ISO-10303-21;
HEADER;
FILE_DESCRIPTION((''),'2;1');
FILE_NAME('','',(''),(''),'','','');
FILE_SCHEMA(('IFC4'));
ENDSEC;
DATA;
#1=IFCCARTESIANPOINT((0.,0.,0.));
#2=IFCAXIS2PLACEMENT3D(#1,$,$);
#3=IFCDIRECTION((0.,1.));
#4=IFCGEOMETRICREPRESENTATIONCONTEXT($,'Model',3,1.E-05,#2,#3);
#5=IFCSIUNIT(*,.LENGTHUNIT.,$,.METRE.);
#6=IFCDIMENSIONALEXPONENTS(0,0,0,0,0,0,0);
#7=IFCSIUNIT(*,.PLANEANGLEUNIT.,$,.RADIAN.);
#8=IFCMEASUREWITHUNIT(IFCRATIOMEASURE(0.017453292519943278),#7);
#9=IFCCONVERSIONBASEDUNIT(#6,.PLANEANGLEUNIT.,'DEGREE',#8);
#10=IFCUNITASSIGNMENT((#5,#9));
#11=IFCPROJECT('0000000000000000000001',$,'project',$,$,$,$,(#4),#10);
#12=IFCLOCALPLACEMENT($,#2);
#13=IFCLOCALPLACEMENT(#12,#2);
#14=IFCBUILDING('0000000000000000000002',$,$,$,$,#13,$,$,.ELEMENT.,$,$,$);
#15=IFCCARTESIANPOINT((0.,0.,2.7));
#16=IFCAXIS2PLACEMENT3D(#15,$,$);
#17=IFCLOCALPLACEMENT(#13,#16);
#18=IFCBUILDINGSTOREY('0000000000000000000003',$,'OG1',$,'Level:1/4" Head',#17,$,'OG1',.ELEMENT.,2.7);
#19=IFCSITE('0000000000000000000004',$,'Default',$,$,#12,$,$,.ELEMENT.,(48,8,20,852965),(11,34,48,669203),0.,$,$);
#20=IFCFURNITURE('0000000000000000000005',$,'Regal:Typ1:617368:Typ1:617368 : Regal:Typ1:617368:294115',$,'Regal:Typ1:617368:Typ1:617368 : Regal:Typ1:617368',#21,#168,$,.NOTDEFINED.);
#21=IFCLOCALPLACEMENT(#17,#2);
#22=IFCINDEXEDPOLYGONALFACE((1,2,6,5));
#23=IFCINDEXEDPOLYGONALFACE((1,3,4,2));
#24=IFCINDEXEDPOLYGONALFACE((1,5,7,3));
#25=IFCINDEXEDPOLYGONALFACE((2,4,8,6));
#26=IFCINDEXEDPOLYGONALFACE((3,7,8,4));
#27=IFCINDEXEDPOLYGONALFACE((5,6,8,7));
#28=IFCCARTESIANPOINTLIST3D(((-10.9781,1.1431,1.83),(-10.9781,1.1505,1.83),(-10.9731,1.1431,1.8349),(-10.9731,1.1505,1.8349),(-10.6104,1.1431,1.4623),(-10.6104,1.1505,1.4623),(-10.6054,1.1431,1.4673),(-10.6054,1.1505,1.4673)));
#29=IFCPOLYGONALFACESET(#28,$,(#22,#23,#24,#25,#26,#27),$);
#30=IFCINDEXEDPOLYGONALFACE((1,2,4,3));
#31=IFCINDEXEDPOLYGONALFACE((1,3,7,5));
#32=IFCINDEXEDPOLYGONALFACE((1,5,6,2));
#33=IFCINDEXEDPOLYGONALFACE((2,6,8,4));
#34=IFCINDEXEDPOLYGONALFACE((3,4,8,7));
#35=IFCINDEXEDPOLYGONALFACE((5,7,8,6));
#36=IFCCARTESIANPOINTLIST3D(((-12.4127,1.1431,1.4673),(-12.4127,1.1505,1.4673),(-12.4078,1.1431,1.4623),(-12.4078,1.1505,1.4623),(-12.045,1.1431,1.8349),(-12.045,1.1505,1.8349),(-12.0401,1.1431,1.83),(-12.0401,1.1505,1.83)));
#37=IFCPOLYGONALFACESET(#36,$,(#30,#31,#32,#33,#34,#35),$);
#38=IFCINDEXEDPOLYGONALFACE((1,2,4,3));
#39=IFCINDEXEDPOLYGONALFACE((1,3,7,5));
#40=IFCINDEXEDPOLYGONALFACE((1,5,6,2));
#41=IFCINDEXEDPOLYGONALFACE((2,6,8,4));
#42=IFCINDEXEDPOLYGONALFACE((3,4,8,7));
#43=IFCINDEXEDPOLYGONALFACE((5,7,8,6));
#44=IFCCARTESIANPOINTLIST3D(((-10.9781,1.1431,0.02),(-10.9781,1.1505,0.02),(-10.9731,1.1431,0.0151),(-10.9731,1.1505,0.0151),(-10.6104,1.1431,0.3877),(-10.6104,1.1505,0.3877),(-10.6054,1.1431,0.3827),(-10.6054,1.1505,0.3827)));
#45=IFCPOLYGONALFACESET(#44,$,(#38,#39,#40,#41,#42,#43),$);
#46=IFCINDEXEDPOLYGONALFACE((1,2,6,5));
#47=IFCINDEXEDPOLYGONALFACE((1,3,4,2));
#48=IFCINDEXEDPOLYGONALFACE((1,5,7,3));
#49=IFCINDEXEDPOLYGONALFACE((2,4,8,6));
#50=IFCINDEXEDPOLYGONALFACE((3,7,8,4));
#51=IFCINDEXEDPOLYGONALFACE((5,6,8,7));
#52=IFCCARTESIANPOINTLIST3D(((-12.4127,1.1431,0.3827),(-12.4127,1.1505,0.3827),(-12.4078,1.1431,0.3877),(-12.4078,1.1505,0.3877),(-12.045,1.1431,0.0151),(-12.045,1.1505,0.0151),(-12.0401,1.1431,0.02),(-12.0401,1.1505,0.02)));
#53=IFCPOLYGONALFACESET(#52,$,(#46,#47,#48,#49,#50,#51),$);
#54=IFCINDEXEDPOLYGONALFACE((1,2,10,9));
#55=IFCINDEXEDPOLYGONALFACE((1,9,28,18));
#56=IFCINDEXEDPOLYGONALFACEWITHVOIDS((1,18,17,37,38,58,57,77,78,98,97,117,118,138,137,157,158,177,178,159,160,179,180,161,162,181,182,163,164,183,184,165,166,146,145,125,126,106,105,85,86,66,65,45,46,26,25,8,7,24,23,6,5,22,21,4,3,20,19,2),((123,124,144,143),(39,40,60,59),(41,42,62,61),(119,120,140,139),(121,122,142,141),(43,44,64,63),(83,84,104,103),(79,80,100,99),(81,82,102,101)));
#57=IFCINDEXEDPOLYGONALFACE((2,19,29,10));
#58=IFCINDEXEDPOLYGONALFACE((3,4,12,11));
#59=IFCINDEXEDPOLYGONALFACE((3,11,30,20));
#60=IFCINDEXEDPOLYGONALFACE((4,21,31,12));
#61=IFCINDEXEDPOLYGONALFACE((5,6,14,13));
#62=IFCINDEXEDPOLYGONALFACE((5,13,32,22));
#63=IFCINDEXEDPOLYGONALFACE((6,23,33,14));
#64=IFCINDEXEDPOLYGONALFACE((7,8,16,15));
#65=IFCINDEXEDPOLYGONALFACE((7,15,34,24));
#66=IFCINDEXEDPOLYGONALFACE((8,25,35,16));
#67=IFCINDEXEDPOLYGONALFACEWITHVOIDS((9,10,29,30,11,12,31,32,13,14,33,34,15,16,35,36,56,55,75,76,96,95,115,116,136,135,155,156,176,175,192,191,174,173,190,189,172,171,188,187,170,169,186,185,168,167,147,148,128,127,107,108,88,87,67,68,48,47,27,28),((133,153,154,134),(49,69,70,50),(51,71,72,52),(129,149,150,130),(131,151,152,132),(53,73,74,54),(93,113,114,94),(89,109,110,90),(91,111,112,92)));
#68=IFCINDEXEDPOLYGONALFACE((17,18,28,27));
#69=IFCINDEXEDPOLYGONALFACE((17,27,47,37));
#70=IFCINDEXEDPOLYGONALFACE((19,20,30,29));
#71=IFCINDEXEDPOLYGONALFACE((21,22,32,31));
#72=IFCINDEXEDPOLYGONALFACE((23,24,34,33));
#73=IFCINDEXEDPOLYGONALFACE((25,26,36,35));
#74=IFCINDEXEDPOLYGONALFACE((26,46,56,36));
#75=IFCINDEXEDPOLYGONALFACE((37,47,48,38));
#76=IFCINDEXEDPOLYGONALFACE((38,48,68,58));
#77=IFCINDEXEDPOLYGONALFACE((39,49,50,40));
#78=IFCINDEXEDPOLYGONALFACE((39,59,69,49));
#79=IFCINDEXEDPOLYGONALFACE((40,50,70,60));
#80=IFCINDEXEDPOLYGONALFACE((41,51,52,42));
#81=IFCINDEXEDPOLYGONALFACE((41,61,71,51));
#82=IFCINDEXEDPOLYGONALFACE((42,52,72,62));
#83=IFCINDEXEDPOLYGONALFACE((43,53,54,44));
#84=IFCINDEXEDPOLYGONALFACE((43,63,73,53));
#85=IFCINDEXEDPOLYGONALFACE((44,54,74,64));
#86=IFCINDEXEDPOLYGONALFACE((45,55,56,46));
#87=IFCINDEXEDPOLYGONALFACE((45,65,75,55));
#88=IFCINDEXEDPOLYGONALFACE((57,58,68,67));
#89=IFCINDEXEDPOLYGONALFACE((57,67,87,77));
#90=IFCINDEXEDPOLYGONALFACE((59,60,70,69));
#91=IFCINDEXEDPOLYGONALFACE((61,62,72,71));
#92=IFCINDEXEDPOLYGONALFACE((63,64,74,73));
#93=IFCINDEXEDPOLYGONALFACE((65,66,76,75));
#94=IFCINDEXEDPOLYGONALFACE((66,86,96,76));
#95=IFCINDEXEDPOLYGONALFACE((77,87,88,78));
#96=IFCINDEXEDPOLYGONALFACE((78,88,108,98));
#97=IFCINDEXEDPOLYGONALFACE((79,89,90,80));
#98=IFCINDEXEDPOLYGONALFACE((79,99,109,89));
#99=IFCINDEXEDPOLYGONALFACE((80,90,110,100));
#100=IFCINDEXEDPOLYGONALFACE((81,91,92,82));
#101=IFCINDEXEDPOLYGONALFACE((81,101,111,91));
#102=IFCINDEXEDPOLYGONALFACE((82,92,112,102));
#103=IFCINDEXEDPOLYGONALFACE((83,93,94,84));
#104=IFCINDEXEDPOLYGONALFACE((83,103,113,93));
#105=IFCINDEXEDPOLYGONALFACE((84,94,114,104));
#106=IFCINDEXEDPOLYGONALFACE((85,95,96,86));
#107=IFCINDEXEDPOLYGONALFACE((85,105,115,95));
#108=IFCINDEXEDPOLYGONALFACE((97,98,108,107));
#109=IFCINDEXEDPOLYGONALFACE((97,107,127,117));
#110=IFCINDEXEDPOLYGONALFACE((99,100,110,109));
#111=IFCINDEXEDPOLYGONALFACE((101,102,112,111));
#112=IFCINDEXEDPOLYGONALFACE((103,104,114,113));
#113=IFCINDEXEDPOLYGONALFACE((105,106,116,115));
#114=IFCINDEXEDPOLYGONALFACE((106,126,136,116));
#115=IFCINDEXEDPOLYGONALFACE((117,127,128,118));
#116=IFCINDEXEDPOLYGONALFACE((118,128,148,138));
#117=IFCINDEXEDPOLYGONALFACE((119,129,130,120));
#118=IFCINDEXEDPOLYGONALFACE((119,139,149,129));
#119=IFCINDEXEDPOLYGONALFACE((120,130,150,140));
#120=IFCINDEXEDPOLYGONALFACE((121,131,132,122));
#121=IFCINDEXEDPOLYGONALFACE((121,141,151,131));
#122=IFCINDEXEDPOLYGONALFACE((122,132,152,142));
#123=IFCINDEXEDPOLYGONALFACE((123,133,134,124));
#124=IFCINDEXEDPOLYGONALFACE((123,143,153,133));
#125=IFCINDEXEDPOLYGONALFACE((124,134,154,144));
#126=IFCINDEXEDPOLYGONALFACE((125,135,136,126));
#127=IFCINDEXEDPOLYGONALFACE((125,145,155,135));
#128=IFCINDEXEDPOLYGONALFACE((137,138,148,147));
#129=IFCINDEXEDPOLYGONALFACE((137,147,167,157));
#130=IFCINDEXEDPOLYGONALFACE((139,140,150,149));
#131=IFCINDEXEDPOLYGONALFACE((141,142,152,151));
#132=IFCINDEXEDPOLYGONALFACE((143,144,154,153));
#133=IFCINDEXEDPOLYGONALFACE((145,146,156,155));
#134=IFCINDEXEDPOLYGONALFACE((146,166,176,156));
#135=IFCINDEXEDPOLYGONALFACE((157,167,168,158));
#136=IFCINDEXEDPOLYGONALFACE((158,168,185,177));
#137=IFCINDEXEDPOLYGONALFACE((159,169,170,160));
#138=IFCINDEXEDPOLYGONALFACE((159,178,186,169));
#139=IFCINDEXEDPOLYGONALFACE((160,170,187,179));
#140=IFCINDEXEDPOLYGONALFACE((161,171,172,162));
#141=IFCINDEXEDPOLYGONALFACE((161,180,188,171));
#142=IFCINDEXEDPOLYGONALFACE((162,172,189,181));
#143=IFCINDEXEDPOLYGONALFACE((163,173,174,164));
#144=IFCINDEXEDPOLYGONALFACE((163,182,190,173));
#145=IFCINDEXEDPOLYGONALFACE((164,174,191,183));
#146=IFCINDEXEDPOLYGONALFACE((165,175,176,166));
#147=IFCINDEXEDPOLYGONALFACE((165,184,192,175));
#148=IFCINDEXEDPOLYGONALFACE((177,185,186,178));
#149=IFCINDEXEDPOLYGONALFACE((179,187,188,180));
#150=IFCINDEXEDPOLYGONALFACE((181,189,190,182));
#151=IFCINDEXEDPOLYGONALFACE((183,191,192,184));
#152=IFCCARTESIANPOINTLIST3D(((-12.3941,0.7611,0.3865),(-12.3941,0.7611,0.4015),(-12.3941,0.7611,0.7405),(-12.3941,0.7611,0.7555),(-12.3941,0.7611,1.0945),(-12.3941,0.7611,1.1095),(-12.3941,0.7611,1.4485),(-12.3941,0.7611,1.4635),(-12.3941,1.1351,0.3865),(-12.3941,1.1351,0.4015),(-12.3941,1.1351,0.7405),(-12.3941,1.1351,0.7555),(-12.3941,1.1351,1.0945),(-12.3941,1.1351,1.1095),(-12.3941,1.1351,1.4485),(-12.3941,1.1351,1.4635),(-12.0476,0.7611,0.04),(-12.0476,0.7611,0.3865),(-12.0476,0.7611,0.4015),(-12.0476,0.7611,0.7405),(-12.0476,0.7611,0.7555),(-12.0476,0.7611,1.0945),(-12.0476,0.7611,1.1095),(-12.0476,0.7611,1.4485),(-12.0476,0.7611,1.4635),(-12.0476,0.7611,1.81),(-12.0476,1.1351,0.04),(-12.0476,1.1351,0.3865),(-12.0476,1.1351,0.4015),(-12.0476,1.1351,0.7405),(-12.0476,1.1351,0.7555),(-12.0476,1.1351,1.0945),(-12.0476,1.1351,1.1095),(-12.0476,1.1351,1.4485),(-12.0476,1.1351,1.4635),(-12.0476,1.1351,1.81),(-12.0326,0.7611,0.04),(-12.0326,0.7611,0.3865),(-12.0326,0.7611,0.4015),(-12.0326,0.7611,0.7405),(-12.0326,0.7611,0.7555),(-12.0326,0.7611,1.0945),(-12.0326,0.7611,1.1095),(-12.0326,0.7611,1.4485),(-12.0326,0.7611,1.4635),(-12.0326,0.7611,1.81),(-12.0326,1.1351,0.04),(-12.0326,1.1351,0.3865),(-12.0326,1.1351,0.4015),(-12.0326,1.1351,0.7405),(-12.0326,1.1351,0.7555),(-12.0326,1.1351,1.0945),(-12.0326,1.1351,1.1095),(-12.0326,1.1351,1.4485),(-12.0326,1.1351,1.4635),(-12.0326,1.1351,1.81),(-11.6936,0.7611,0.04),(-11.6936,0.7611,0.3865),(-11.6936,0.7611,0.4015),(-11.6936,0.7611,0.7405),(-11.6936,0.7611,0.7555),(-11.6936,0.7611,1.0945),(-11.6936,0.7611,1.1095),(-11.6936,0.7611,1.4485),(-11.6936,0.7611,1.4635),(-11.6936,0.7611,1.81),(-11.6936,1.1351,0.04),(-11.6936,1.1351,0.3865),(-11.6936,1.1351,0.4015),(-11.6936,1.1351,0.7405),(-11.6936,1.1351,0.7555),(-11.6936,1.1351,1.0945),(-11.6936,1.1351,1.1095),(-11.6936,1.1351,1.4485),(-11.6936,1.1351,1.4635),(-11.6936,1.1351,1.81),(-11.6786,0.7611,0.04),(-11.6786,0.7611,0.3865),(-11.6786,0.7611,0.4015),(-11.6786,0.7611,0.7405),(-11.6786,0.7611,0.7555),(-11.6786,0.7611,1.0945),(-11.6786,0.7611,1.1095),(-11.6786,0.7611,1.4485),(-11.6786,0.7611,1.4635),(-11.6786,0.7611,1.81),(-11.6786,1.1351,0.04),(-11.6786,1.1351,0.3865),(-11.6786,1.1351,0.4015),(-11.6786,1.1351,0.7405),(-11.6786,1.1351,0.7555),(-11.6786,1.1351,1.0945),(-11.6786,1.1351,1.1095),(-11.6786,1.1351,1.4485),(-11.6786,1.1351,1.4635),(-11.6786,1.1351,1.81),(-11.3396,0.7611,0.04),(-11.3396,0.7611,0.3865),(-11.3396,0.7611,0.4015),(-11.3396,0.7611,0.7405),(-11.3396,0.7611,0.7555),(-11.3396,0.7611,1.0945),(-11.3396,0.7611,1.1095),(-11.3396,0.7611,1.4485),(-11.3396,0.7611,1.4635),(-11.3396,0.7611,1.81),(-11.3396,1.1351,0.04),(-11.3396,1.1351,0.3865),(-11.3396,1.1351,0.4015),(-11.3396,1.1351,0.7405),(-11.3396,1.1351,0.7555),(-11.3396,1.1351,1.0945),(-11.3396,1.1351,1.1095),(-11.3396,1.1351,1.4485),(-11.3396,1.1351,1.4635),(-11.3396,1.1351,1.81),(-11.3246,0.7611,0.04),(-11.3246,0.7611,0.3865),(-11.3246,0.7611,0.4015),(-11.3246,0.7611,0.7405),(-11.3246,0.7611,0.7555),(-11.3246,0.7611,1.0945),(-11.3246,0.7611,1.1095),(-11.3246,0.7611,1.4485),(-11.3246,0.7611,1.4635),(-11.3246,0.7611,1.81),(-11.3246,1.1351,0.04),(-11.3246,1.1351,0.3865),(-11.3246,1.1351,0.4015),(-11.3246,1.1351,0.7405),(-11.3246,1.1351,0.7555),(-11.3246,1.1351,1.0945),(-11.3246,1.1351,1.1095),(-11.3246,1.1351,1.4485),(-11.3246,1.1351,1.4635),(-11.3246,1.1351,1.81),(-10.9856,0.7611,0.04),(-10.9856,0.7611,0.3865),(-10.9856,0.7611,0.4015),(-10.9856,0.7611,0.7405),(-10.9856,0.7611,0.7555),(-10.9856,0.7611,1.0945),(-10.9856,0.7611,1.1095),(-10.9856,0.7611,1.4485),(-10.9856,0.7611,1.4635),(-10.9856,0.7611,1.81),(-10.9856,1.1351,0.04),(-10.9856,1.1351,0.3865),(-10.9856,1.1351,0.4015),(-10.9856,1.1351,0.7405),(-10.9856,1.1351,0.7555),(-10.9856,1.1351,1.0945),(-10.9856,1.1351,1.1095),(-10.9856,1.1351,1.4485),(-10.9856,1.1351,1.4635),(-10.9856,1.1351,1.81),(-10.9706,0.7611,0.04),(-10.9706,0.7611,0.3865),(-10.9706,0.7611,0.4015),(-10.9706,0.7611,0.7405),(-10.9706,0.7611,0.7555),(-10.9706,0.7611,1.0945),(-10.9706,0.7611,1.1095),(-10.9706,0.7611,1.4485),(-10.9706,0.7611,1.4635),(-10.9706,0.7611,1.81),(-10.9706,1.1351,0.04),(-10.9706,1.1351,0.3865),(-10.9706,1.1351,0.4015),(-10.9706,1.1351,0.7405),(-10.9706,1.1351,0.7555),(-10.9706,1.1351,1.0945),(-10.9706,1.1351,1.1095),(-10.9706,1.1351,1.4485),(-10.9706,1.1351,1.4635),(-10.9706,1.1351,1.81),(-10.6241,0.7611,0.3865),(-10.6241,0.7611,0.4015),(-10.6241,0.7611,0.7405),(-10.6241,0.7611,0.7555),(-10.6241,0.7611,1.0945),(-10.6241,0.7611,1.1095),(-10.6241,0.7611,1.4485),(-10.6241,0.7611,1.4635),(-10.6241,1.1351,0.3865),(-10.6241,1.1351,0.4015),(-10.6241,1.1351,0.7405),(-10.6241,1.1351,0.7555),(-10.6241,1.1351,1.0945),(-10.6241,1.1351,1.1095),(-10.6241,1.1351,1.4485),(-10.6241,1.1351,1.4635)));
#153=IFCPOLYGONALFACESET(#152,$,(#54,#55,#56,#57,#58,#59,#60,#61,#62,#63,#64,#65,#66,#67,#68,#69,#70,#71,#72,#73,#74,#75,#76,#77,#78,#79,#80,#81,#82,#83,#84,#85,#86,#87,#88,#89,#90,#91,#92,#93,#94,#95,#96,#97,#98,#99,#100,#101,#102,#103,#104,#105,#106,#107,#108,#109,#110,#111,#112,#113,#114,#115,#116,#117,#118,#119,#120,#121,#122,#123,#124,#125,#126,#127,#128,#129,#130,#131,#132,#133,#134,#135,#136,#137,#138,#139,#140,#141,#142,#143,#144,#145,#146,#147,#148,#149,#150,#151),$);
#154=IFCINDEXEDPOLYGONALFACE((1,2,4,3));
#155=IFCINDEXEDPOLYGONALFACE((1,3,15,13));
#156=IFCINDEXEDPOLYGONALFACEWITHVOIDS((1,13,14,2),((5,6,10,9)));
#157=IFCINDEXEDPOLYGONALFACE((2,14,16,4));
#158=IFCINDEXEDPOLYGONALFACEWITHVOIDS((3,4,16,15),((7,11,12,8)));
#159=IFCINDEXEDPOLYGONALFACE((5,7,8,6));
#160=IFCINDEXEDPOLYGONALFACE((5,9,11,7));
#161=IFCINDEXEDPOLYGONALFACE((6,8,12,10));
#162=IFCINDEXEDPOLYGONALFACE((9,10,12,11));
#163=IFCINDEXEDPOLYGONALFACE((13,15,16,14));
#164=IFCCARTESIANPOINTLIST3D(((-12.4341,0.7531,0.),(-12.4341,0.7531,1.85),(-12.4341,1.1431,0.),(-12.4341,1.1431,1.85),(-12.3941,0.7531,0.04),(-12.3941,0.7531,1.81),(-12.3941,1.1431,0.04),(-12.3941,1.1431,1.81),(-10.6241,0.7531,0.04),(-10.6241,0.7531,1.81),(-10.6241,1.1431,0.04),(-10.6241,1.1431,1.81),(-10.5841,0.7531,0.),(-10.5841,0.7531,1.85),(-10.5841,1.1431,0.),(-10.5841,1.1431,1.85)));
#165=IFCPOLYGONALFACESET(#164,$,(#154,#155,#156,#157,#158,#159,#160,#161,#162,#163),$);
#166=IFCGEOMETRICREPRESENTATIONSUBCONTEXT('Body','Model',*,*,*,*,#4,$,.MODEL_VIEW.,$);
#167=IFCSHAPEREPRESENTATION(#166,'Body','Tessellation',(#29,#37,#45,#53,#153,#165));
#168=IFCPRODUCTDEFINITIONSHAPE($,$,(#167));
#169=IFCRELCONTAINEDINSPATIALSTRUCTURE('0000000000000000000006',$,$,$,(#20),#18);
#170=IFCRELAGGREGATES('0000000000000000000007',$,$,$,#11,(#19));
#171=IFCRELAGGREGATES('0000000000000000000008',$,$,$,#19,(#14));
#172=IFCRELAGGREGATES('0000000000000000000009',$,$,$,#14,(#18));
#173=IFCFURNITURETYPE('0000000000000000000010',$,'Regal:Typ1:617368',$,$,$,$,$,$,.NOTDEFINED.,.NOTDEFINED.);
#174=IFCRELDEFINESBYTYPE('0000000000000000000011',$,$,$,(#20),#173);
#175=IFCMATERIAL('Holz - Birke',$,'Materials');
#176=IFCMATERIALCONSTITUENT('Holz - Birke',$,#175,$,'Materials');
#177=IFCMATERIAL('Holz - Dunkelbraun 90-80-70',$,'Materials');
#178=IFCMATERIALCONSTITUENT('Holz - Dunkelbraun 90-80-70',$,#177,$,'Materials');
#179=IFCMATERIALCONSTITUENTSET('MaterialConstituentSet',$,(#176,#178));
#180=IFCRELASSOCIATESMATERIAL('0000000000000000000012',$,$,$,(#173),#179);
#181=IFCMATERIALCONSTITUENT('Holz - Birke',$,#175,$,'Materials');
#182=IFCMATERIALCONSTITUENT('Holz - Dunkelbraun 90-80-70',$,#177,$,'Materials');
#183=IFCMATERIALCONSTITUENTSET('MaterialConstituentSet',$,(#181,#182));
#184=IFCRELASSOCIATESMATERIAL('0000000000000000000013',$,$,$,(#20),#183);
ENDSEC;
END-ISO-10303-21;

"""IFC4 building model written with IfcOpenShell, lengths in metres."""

from ifc_helpers import new_model, entity, si_unit, converted_unit, direction, frame, origin, place, context, subcontext, project, spatial, indexed_curve, outline, extrude, source, transform, mapped, material, constituent, constituent_set, type_object, type_shapes, element, save


model = new_model("IFC4")

# Units and contexts
model_context = context("Model", 3, precision=1e-05, world=origin(), true_north=direction((0.0, 1.0)))
body_context = subcontext(model_context, "Body", "Model", "MODEL_VIEW")
ifc_project = project(units=[si_unit("LENGTHUNIT", "METRE"), converted_unit("PLANEANGLEUNIT", "DEGREE", entity("IfcRatioMeasure", 0.017453292519943278), si_unit("PLANEANGLEUNIT", "RADIAN"), dimensions=[0, 0, 0, 0, 0, 0, 0])], contexts=[model_context])

# Site, building, storey
site_placement = place(None, origin())
site = spatial("IfcSite", under=ifc_project, at=site_placement, Name="Default", CompositionType="ELEMENT", RefLatitude=(48, 8, 20, 852965), RefLongitude=(11, 34, 48, 669203), RefElevation=0.0)
building_placement = place(site_placement, origin())
building = spatial("IfcBuilding", under=site, at=building_placement, CompositionType="ELEMENT")
storey_placement = place(building_placement, frame((0.0, 0.0, 2.7)))
storey = spatial("IfcBuildingStorey", under=building, at=storey_placement, Name="OG1", ObjectType="Level:1/4\" Head", LongName="OG1", CompositionType="ELEMENT", Elevation=2.7)

# Shared definitions
ifc_material_1 = material(Name="Holz - Birke", Category="Materials")

# Furniture
ifc_constituent_1 = constituent(ifc_material_1, Name="Holz - Birke", Category="Materials")
ifc_material_2 = material(Name="Holz - Dunkelbraun 90-80-70", Category="Materials")
ifc_constituent_2 = constituent(ifc_material_2, Name="Holz - Dunkelbraun 90-80-70", Category="Materials")
ifc_constituent_set_1 = constituent_set(constituents=[ifc_constituent_1, ifc_constituent_2], Name="MaterialConstituentSet")
ifc_constituent_3 = constituent(ifc_material_1, Name="Holz - Birke", Category="Materials")
ifc_constituent_4 = constituent(ifc_material_2, Name="Holz - Dunkelbraun 90-80-70", Category="Materials")
ifc_constituent_set_2 = constituent_set(constituents=[ifc_constituent_3, ifc_constituent_4], Name="MaterialConstituentSet")
furniture_type_1 = type_object("IfcFurnitureType", Name="Regal:Typ1:617368", AssemblyPlace="NOTDEFINED", PredefinedType="NOTDEFINED", material=ifc_constituent_set_2)
shared_shape_1 = source(origin(), body_context, "Body", "SweptSolid", [
    extrude(outline(indexed_curve([(-0.0035, -0.0037), (0.0035, -0.0037), (0.0035, 0.0037), (-0.0035, 0.0037), (-0.0035, -0.0037)], self_intersect=False)), frame((-10.6079, 1.1468, 4.1648), z_axis=(-0.707107, 0.0, 0.707107), x_axis=(-0.707107, 0.0, -0.707107)), (0.0, 0.0, 1.0), 0.52),
    extrude(outline(indexed_curve([(-0.0035, -0.0037), (0.0035, -0.0037), (0.0035, 0.0037), (-0.0035, 0.0037), (-0.0035, -0.0037)], self_intersect=False)), frame((-12.4102, 1.1468, 4.1648), z_axis=(0.707107, 0.0, 0.707107), x_axis=(-0.707107, 0.0, 0.707107)), (0.0, 0.0, 1.0), 0.52),
    extrude(outline(indexed_curve([(-0.0035, -0.0037), (0.0035, -0.0037), (0.0035, 0.0037), (-0.0035, 0.0037), (-0.0035, -0.0037)], self_intersect=False)), frame((-10.9756, 1.1468, 2.7175), z_axis=(0.707107, 0.0, 0.707107), x_axis=(-0.707107, 0.0, 0.707107)), (0.0, 0.0, 1.0), 0.52),
    extrude(outline(indexed_curve([(-0.0035, -0.0037), (0.0035, -0.0037), (0.0035, 0.0037), (-0.0035, 0.0037), (-0.0035, -0.0037)], self_intersect=False)), frame((-12.0425, 1.1468, 2.7175), z_axis=(-0.707107, 0.0, 0.707107), x_axis=(-0.707107, 0.0, -0.707107)), (0.0, 0.0, 1.0), 0.52),
    extrude(outline(indexed_curve([(-0.5385, -0.885), (-0.5235, -0.885), (-0.5235, -0.5385), (-0.1845, -0.5385), (-0.1845, -0.885), (-0.1695, -0.885), (-0.1695, -0.5385), (0.1695, -0.5385), (0.1695, -0.885), (0.1845, -0.885), (0.1845, -0.5385), (0.5235, -0.5385), (0.5235, -0.885), (0.5385, -0.885), (0.5385, -0.5385), (0.885, -0.5385), (0.885, -0.5235), (0.5385, -0.5235), (0.5385, -0.1845), (0.885, -0.1845), (0.885, -0.1695), (0.5385, -0.1695), (0.5385, 0.1695), (0.885, 0.1695), (0.885, 0.1845), (0.5385, 0.1845), (0.5385, 0.5235), (0.885, 0.5235), (0.885, 0.5385), (0.5385, 0.5385), (0.5385, 0.885), (0.5235, 0.885), (0.5235, 0.5385), (0.1845, 0.5385), (0.1845, 0.885), (0.1695, 0.885), (0.1695, 0.5385), (-0.1695, 0.5385), (-0.1695, 0.885), (-0.1845, 0.885), (-0.1845, 0.5385), (-0.5235, 0.5385), (-0.5235, 0.885), (-0.5385, 0.885), (-0.5385, 0.5385), (-0.885, 0.5385), (-0.885, 0.5235), (-0.5385, 0.5235), (-0.5385, 0.1845), (-0.885, 0.1845), (-0.885, 0.1695), (-0.5385, 0.1695), (-0.5385, -0.1695), (-0.885, -0.1695), (-0.885, -0.1845), (-0.5385, -0.1845), (-0.5385, -0.5235), (-0.885, -0.5235), (-0.885, -0.5385), (-0.5385, -0.5385), (-0.5385, -0.885)], self_intersect=False), holes=[indexed_curve([(-0.5235, -0.5235), (-0.5235, -0.1845), (-0.1845, -0.1845), (-0.1845, -0.5235), (-0.5235, -0.5235)], self_intersect=False), indexed_curve([(0.1695, -0.1845), (0.1695, -0.5235), (-0.1695, -0.5235), (-0.1695, -0.1845), (0.1695, -0.1845)], self_intersect=False), indexed_curve([(0.5235, -0.1845), (0.5235, -0.5235), (0.1845, -0.5235), (0.1845, -0.1845), (0.5235, -0.1845)], self_intersect=False), indexed_curve([(0.5235, -0.1695), (0.1845, -0.1695), (0.1845, 0.1695), (0.5235, 0.1695), (0.5235, -0.1695)], self_intersect=False), indexed_curve([(0.1695, -0.1695), (-0.1695, -0.1695), (-0.1695, 0.1695), (0.1695, 0.1695), (0.1695, -0.1695)], self_intersect=False), indexed_curve([(-0.1845, -0.1695), (-0.5235, -0.1695), (-0.5235, 0.1695), (-0.1845, 0.1695), (-0.1845, -0.1695)], self_intersect=False), indexed_curve([(-0.1845, 0.5235), (-0.1845, 0.1845), (-0.5235, 0.1845), (-0.5235, 0.5235), (-0.1845, 0.5235)], self_intersect=False), indexed_curve([(0.1695, 0.5235), (0.1695, 0.1845), (-0.1695, 0.1845), (-0.1695, 0.5235), (0.1695, 0.5235)], self_intersect=False), indexed_curve([(0.5235, 0.5235), (0.5235, 0.1845), (0.1845, 0.1845), (0.1845, 0.5235), (0.5235, 0.5235)], self_intersect=False)]), frame((-11.5091, 0.7611, 3.625), z_axis=(0.0, 1.0, 0.0), x_axis=(1.0, 0.0, 0.0)), (0.0, 0.0, 1.0), 0.374),
    extrude(outline(indexed_curve([(-0.925, -0.925), (0.925, -0.925), (0.925, 0.925), (-0.925, 0.925), (-0.925, -0.925)], self_intersect=False), holes=[indexed_curve([(0.885, 0.885), (0.885, -0.885), (-0.885, -0.885), (-0.885, 0.885), (0.885, 0.885)], self_intersect=False)]), frame((-11.5091, 0.7531, 3.625), z_axis=(0.0, 1.0, 0.0), x_axis=(-1.0, 0.0, 0.0)), (0.0, 0.0, 1.0), 0.39),
])
type_shapes(furniture_type_1, [shared_shape_1])
furniture_1_placement = place(storey_placement, frame((0.0, 0.0, -2.7)))
element("IfcFurniture", 1, at=furniture_1_placement, inside=storey, type_object=furniture_type_1, material=ifc_constituent_set_1, Name="Regal:Typ1:617368:Typ1:617368 : Regal:Typ1:617368:294115", ObjectType="Regal:Typ1:617368:Typ1:617368 : Regal:Typ1:617368", PredefinedType="NOTDEFINED", context=body_context, shape_type="MappedRepresentation", body=[
    mapped(shared_shape_1, transform((0.0, 0.0, 0.0), scale=1.0)),
])

save(model, "model.ifc")
